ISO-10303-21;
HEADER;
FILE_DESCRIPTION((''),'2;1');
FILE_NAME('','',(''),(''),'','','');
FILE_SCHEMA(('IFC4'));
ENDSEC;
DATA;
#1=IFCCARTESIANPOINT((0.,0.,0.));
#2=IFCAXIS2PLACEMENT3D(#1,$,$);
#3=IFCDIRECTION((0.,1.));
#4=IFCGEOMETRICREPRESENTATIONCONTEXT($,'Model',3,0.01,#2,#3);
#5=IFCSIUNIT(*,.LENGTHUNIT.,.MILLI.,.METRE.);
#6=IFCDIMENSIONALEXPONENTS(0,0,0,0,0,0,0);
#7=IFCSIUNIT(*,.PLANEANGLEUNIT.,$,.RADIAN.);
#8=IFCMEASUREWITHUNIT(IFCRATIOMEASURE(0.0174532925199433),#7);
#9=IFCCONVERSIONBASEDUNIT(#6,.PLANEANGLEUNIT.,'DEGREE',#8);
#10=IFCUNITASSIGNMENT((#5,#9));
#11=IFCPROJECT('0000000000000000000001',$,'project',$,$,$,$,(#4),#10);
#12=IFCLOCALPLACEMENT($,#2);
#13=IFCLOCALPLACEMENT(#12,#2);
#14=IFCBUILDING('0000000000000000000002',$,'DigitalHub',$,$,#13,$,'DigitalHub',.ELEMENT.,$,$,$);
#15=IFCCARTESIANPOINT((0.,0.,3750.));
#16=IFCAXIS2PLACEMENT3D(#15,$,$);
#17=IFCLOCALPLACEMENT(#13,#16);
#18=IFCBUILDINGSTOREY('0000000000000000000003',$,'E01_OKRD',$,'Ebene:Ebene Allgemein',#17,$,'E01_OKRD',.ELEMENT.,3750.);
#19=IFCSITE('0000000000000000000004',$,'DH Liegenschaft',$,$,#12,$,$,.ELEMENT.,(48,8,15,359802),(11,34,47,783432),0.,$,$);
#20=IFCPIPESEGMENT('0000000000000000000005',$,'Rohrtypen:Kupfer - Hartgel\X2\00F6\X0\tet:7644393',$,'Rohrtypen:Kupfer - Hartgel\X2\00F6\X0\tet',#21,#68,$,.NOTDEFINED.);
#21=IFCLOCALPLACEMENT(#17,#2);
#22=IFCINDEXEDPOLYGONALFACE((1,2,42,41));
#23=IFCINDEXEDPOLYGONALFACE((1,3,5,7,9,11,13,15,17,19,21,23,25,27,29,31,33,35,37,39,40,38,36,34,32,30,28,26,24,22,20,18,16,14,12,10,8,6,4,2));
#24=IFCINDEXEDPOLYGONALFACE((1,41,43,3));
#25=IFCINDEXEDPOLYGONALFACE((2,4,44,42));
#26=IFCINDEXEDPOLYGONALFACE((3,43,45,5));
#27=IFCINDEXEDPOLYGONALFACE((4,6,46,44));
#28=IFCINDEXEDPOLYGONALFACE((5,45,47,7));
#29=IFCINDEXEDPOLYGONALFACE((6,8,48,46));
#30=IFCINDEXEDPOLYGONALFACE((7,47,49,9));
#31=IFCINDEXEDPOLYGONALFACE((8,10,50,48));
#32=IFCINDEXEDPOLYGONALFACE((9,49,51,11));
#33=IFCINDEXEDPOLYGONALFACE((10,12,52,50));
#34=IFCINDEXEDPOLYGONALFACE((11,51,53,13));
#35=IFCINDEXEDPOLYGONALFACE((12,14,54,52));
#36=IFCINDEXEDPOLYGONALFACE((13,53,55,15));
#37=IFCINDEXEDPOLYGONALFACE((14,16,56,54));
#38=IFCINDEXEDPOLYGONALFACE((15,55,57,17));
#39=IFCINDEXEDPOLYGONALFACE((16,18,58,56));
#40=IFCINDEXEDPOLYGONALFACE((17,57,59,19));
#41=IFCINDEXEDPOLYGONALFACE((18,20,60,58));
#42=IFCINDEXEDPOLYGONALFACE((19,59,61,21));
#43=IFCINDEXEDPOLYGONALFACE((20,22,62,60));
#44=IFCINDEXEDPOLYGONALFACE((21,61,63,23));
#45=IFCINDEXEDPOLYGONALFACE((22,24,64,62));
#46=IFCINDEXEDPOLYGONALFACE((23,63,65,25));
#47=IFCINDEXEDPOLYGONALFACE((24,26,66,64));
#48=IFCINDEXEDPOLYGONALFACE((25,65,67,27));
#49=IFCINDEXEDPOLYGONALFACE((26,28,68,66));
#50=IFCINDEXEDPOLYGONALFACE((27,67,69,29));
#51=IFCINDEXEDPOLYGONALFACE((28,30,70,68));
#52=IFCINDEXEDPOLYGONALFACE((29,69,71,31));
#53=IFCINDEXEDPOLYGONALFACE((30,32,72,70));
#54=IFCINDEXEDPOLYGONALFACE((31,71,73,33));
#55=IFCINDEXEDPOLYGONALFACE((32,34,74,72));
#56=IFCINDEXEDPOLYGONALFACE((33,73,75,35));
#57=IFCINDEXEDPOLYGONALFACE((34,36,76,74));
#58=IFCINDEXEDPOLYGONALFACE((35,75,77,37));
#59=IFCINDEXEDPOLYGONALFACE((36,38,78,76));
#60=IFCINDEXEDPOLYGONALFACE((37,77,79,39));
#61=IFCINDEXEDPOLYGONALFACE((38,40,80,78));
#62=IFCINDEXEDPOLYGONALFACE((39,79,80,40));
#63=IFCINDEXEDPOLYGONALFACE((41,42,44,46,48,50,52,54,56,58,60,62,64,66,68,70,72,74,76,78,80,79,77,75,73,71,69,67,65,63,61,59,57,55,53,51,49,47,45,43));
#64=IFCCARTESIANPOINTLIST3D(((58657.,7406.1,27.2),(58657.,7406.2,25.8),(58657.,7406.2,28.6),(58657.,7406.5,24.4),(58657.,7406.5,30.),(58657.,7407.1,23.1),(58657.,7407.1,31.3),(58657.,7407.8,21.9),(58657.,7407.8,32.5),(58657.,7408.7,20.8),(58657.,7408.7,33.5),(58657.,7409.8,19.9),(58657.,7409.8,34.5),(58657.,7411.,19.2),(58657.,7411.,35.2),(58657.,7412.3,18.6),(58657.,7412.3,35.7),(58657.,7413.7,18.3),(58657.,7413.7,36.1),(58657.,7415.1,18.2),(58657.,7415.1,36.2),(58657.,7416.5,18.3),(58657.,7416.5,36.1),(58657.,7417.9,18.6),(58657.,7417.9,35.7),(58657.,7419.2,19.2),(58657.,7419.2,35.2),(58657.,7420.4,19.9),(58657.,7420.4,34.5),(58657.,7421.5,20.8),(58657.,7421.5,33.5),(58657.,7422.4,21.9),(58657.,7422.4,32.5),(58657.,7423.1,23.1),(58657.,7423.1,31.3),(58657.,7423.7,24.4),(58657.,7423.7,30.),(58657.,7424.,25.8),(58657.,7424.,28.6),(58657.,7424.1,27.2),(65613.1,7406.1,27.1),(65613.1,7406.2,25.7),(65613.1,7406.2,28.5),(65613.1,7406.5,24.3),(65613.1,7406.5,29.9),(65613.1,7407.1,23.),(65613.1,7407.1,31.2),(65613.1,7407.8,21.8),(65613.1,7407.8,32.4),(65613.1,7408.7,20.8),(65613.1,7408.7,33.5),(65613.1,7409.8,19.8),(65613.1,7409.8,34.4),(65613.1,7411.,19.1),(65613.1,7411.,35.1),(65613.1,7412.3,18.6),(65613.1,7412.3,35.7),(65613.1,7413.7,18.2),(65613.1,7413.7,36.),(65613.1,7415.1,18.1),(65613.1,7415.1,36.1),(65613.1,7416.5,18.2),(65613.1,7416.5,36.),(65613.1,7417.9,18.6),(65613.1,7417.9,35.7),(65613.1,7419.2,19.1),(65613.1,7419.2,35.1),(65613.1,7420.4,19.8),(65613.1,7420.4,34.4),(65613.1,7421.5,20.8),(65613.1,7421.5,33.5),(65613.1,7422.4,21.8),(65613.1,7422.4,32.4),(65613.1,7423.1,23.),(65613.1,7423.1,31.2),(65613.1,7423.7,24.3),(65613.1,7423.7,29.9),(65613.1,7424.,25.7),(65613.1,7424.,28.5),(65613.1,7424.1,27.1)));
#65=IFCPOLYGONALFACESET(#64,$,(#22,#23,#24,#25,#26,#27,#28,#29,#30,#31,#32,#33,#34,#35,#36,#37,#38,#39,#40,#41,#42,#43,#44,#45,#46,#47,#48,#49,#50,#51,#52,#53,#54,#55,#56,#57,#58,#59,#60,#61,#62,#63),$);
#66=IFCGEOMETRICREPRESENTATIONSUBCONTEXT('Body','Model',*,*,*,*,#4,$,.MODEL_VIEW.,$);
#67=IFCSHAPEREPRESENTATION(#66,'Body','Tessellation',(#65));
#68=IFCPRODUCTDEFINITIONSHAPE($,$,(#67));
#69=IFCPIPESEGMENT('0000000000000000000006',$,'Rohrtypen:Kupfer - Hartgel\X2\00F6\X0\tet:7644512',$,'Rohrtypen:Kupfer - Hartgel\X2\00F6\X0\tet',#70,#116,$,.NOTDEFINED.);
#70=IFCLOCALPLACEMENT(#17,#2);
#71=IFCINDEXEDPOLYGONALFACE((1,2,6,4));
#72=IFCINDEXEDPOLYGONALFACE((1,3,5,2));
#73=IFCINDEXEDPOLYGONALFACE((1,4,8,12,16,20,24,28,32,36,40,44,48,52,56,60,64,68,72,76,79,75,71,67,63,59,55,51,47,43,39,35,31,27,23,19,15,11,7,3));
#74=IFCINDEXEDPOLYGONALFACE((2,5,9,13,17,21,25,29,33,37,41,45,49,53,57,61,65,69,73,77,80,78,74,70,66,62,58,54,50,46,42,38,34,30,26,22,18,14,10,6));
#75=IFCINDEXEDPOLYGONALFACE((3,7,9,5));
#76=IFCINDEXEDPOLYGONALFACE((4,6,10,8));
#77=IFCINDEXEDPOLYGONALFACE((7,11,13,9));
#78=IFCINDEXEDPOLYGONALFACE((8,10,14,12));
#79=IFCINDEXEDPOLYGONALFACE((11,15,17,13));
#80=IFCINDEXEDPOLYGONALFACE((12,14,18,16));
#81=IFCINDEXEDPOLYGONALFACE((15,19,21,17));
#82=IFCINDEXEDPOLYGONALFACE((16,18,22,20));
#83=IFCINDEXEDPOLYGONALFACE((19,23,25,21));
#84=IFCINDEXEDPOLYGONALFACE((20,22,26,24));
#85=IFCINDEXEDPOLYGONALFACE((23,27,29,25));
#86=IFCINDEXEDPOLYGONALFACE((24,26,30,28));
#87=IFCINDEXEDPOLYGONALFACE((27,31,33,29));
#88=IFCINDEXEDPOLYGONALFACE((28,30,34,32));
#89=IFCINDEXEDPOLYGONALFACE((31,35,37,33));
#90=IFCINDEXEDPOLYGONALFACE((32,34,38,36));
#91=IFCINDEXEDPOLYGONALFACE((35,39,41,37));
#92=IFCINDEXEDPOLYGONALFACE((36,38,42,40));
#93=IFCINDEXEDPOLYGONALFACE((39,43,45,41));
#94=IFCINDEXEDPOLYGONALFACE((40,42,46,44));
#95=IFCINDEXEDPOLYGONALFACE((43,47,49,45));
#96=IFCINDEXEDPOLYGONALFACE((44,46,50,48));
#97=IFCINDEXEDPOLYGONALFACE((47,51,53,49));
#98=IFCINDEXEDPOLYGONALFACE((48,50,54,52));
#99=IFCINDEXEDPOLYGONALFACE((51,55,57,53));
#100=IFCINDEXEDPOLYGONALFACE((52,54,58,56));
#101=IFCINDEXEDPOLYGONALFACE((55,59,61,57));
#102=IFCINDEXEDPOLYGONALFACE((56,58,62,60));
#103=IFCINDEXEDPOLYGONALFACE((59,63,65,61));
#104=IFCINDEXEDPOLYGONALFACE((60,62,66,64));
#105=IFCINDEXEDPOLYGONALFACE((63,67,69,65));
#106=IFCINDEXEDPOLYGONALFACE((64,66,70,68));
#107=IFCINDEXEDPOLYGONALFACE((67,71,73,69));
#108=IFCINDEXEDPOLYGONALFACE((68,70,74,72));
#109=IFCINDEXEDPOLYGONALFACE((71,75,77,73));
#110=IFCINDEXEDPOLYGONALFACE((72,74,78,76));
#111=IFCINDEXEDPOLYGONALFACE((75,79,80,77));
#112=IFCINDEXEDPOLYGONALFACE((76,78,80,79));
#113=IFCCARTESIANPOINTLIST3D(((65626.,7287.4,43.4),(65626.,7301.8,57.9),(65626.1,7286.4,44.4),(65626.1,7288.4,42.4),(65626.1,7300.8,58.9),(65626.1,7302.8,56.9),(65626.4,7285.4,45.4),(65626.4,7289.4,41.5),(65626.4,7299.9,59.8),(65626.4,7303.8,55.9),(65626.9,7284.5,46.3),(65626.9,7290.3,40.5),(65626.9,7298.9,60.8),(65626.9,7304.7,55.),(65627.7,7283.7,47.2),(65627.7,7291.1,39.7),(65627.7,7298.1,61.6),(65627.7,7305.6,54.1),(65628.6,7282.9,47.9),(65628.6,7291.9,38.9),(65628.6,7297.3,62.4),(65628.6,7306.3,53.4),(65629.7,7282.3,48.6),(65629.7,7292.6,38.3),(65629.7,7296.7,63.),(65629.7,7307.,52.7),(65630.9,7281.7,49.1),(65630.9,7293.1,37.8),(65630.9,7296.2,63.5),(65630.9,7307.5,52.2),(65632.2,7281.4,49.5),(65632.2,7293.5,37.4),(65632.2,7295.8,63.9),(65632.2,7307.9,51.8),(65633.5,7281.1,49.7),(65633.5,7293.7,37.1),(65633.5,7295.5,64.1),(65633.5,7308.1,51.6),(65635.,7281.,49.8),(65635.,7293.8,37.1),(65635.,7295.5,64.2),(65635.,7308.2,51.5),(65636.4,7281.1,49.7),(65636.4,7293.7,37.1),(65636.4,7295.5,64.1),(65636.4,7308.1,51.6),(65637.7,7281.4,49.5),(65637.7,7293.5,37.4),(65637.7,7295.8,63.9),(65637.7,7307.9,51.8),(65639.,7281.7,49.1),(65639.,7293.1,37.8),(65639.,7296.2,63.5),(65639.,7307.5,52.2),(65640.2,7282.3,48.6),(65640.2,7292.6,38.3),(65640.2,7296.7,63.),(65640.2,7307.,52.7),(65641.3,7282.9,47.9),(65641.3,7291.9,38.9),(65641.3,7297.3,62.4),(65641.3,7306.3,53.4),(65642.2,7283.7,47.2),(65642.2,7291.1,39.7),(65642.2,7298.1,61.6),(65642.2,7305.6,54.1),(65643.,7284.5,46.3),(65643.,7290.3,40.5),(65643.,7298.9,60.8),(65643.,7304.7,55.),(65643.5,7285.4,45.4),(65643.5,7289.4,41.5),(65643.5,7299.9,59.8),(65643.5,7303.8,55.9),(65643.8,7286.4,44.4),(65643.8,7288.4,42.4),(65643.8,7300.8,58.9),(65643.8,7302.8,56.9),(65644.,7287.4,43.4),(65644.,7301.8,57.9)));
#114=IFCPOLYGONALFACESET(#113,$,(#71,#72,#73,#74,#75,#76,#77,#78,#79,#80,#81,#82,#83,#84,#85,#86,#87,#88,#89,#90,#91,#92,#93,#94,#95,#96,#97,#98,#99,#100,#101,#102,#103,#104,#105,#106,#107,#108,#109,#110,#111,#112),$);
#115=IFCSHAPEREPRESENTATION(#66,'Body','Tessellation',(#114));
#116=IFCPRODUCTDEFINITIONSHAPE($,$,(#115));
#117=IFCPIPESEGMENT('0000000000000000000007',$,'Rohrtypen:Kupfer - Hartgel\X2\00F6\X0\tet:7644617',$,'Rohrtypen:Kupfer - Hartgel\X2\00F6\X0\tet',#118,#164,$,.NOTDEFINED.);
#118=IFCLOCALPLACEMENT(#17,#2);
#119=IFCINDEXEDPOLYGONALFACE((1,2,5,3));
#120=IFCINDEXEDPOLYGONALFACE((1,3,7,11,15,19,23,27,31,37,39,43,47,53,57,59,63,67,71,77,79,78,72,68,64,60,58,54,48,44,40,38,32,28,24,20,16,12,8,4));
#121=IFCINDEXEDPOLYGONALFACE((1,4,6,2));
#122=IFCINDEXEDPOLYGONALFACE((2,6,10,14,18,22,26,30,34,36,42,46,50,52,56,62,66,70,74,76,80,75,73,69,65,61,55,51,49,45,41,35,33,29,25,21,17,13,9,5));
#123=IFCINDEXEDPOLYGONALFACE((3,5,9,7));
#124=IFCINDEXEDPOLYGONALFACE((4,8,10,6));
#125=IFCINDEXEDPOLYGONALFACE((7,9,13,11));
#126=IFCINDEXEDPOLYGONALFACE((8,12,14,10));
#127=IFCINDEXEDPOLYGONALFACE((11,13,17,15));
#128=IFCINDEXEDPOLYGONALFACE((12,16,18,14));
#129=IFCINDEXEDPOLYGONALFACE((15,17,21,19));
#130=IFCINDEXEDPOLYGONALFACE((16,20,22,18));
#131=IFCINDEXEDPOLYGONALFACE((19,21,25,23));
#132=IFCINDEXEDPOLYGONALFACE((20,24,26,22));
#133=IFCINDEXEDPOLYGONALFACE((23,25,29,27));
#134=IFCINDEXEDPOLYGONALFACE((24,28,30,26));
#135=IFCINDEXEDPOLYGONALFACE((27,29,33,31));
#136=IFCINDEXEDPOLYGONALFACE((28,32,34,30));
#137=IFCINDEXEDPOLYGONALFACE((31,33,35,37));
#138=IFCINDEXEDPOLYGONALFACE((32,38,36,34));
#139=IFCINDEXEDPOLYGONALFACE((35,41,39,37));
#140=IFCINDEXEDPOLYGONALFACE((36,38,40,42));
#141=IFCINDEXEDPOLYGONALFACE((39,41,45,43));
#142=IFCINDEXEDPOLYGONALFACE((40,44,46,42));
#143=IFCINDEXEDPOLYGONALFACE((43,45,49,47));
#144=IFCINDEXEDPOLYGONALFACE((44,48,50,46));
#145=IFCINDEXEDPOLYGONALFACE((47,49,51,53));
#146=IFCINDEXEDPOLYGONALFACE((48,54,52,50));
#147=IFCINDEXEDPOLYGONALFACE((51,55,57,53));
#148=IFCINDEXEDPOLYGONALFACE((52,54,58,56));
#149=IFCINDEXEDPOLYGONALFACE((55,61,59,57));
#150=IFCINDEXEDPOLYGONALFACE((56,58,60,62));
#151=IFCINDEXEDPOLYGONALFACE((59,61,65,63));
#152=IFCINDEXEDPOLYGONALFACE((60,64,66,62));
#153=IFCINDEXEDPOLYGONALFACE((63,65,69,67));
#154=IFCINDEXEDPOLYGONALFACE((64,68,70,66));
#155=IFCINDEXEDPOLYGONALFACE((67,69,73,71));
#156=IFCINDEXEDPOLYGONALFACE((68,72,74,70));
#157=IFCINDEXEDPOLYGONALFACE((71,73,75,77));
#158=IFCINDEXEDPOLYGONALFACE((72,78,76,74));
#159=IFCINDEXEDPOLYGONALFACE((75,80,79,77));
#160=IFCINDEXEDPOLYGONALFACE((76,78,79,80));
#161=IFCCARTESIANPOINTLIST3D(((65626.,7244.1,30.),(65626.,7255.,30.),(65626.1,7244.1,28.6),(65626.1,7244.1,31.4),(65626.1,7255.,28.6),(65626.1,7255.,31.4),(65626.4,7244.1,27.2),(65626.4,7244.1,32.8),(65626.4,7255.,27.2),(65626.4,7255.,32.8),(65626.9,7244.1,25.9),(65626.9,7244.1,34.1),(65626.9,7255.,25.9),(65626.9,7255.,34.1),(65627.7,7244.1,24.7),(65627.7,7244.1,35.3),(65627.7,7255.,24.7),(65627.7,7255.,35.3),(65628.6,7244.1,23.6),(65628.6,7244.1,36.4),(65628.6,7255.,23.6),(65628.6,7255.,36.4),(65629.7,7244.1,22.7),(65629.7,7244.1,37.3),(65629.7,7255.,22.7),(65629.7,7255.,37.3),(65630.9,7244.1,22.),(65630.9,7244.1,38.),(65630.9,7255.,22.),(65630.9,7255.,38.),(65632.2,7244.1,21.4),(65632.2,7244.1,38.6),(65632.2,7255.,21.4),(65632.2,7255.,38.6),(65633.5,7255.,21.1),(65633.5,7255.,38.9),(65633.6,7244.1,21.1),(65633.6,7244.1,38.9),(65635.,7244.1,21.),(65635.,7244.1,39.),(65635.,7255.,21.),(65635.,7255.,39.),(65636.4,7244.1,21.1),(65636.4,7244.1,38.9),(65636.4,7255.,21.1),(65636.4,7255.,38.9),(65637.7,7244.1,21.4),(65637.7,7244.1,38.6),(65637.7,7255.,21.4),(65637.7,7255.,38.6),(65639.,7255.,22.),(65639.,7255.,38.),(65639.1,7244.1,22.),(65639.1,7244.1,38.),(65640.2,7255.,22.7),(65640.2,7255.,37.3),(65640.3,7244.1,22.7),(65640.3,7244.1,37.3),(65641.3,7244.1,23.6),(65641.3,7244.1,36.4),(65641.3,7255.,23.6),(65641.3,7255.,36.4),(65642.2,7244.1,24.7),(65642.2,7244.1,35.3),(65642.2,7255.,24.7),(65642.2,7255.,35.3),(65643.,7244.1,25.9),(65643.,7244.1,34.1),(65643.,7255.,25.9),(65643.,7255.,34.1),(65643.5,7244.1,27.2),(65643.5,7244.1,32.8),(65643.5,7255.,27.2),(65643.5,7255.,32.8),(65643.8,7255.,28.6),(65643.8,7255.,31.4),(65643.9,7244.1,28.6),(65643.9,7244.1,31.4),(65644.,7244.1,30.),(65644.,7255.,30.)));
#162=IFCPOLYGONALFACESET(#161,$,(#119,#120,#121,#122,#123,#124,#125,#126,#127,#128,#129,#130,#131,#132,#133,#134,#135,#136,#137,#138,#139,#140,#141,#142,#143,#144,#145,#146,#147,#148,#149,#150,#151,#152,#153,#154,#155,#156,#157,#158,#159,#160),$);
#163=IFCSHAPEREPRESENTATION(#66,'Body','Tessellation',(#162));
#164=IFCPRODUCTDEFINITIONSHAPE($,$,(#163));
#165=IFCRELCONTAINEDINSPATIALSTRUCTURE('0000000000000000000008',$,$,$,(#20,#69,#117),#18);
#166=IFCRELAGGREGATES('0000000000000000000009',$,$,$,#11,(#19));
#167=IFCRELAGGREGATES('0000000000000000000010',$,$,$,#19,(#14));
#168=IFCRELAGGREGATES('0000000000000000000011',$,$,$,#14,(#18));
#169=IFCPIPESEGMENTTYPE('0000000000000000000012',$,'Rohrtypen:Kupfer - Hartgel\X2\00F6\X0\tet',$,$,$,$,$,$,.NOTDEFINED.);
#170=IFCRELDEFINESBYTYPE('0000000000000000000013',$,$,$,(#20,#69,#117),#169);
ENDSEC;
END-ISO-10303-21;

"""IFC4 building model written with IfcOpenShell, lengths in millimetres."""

from ifc_helpers import new_model, entity, si_unit, converted_unit, direction, frame, origin, place, context, subcontext, project, spatial, indexed_curve, outline, extrude, type_object, element, save


model = new_model("IFC4")

# Units and contexts
model_context = context("Model", 3, precision=0.01, world=origin(), true_north=direction((0.0, 1.0)))
body_context = subcontext(model_context, "Body", "Model", "MODEL_VIEW")
ifc_project = project(units=[si_unit("LENGTHUNIT", "METRE", prefix="MILLI"), converted_unit("PLANEANGLEUNIT", "DEGREE", entity("IfcRatioMeasure", 0.0174532925199433), si_unit("PLANEANGLEUNIT", "RADIAN"), dimensions=[0, 0, 0, 0, 0, 0, 0])], contexts=[model_context])

# Site, building, storey
site_placement = place(None, origin())
site = spatial("IfcSite", under=ifc_project, at=site_placement, Name="DH Liegenschaft", CompositionType="ELEMENT", RefLatitude=(48, 8, 15, 359802), RefLongitude=(11, 34, 47, 783432), RefElevation=0.0)
building_placement = place(site_placement, origin())
building = spatial("IfcBuilding", under=site, at=building_placement, Name="DigitalHub", LongName="DigitalHub", CompositionType="ELEMENT")
storey_placement = place(building_placement, frame((0.0, 0.0, 3750.0)))
storey = spatial("IfcBuildingStorey", under=building, at=storey_placement, Name="E01_OKRD", ObjectType="Ebene:Ebene Allgemein", LongName="E01_OKRD", CompositionType="ELEMENT", Elevation=3750.0)

# Pipe segments
pipe_segment_type = type_object("IfcPipeSegmentType", Name="Rohrtypen:Kupfer - Hartgelötet", PredefinedType="NOTDEFINED")
pipe_segment_1_placement = place(storey_placement, frame((58657.0, 7404.5, 16.5)))
element("IfcPipeSegment", 1, at=pipe_segment_1_placement, inside=storey, type_object=pipe_segment_type, Name="Rohrtypen:Kupfer - Hartgelötet:7644393", ObjectType="Rohrtypen:Kupfer - Hartgelötet", PredefinedType="NOTDEFINED", context=body_context, shape_type="SweptSolid", body=[
    extrude(outline(indexed_curve([(9.0, 0.0), (8.9, 1.4), (8.6, 2.8), (8.0, 4.1), (7.3, 5.3), (6.4, 6.4), (5.3, 7.3), (4.1, 8.0), (2.8, 8.6), (1.4, 8.9), (0.0, 9.0), (-1.4, 8.9), (-2.8, 8.6), (-4.1, 8.0), (-5.3, 7.3), (-6.4, 6.4), (-7.3, 5.3), (-8.0, 4.1), (-8.6, 2.8), (-8.9, 1.4), (-9.0, 0.0), (-8.9, -1.4), (-8.6, -2.8), (-8.0, -4.1), (-7.3, -5.3), (-6.4, -6.4), (-5.3, -7.3), (-4.1, -8.0), (-2.8, -8.6), (-1.4, -8.9), (0.0, -9.0), (1.4, -8.9), (2.8, -8.6), (4.1, -8.0), (5.3, -7.3), (6.4, -6.4), (7.3, -5.3), (8.0, -4.1), (8.6, -2.8), (8.9, -1.4), (9.0, 0.0)], self_intersect=False)), frame((0.0, 10.6, 10.7), z_axis=(1.0, 0.0, -0.00001), x_axis=(0.0, -1.0, 0.0)), (0.0, 0.0, 1.0), 6956.1),
])
pipe_segment_2_placement = place(storey_placement, frame((65624.4, 7279.4, 35.5)))
element("IfcPipeSegment", 2, at=pipe_segment_2_placement, inside=storey, type_object=pipe_segment_type, Name="Rohrtypen:Kupfer - Hartgelötet:7644512", ObjectType="Rohrtypen:Kupfer - Hartgelötet", PredefinedType="NOTDEFINED", context=body_context, shape_type="SweptSolid", body=[
    extrude(outline(indexed_curve([(9.0, 0.0), (8.9, 1.4), (8.6, 2.8), (8.0, 4.1), (7.3, 5.3), (6.4, 6.4), (5.3, 7.3), (4.1, 8.0), (2.8, 8.6), (1.4, 8.9), (0.0, 9.0), (-1.4, 8.9), (-2.8, 8.6), (-4.1, 8.0), (-5.3, 7.3), (-6.4, 6.4), (-7.3, 5.3), (-8.0, 4.1), (-8.6, 2.8), (-8.9, 1.4), (-9.0, 0.0), (-8.9, -1.4), (-8.6, -2.8), (-8.0, -4.1), (-7.3, -5.3), (-6.4, -6.4), (-5.3, -7.3), (-4.1, -8.0), (-2.8, -8.6), (-1.4, -8.9), (0.0, -9.0), (1.4, -8.9), (2.8, -8.6), (4.1, -8.0), (5.3, -7.3), (6.4, -6.4), (7.3, -5.3), (8.0, -4.1), (8.6, -2.8), (8.9, -1.4), (9.0, 0.0)], self_intersect=False)), frame((10.6, 8.0, 8.0), z_axis=(0.0, 0.707107, 0.707107), x_axis=(1.0, 0.0, 0.0)), (0.0, 0.0, 1.0), 20.4),
])
pipe_segment_3_placement = place(storey_placement, frame((65624.4, 7244.1, 19.4)))
element("IfcPipeSegment", 3, at=pipe_segment_3_placement, inside=storey, type_object=pipe_segment_type, Name="Rohrtypen:Kupfer - Hartgelötet:7644617", ObjectType="Rohrtypen:Kupfer - Hartgelötet", PredefinedType="NOTDEFINED", context=body_context, shape_type="SweptSolid", body=[
    extrude(outline(indexed_curve([(9.0, 0.0), (8.9, 1.4), (8.6, 2.8), (8.0, 4.1), (7.3, 5.3), (6.4, 6.4), (5.3, 7.3), (4.1, 8.0), (2.8, 8.6), (1.4, 8.9), (0.0, 9.0), (-1.4, 8.9), (-2.8, 8.6), (-4.1, 8.0), (-5.3, 7.3), (-6.4, 6.4), (-7.3, 5.3), (-8.0, 4.1), (-8.6, 2.8), (-8.9, 1.4), (-9.0, 0.0), (-8.9, -1.4), (-8.6, -2.8), (-8.0, -4.1), (-7.3, -5.3), (-6.4, -6.4), (-5.3, -7.3), (-4.1, -8.0), (-2.8, -8.6), (-1.4, -8.9), (0.0, -9.0), (1.4, -8.9), (2.8, -8.6), (4.1, -8.0), (5.3, -7.3), (6.4, -6.4), (7.3, -5.3), (8.0, -4.1), (8.6, -2.8), (8.9, -1.4), (9.0, 0.0)], self_intersect=False)), frame((10.6, 10.8, 10.6), z_axis=(0.000977, -1.0, 0.0), x_axis=(-1.0, -0.000977, 0.0)), (0.0, 0.0, 1.0), 10.8),
])

save(model, "model.ifc")
